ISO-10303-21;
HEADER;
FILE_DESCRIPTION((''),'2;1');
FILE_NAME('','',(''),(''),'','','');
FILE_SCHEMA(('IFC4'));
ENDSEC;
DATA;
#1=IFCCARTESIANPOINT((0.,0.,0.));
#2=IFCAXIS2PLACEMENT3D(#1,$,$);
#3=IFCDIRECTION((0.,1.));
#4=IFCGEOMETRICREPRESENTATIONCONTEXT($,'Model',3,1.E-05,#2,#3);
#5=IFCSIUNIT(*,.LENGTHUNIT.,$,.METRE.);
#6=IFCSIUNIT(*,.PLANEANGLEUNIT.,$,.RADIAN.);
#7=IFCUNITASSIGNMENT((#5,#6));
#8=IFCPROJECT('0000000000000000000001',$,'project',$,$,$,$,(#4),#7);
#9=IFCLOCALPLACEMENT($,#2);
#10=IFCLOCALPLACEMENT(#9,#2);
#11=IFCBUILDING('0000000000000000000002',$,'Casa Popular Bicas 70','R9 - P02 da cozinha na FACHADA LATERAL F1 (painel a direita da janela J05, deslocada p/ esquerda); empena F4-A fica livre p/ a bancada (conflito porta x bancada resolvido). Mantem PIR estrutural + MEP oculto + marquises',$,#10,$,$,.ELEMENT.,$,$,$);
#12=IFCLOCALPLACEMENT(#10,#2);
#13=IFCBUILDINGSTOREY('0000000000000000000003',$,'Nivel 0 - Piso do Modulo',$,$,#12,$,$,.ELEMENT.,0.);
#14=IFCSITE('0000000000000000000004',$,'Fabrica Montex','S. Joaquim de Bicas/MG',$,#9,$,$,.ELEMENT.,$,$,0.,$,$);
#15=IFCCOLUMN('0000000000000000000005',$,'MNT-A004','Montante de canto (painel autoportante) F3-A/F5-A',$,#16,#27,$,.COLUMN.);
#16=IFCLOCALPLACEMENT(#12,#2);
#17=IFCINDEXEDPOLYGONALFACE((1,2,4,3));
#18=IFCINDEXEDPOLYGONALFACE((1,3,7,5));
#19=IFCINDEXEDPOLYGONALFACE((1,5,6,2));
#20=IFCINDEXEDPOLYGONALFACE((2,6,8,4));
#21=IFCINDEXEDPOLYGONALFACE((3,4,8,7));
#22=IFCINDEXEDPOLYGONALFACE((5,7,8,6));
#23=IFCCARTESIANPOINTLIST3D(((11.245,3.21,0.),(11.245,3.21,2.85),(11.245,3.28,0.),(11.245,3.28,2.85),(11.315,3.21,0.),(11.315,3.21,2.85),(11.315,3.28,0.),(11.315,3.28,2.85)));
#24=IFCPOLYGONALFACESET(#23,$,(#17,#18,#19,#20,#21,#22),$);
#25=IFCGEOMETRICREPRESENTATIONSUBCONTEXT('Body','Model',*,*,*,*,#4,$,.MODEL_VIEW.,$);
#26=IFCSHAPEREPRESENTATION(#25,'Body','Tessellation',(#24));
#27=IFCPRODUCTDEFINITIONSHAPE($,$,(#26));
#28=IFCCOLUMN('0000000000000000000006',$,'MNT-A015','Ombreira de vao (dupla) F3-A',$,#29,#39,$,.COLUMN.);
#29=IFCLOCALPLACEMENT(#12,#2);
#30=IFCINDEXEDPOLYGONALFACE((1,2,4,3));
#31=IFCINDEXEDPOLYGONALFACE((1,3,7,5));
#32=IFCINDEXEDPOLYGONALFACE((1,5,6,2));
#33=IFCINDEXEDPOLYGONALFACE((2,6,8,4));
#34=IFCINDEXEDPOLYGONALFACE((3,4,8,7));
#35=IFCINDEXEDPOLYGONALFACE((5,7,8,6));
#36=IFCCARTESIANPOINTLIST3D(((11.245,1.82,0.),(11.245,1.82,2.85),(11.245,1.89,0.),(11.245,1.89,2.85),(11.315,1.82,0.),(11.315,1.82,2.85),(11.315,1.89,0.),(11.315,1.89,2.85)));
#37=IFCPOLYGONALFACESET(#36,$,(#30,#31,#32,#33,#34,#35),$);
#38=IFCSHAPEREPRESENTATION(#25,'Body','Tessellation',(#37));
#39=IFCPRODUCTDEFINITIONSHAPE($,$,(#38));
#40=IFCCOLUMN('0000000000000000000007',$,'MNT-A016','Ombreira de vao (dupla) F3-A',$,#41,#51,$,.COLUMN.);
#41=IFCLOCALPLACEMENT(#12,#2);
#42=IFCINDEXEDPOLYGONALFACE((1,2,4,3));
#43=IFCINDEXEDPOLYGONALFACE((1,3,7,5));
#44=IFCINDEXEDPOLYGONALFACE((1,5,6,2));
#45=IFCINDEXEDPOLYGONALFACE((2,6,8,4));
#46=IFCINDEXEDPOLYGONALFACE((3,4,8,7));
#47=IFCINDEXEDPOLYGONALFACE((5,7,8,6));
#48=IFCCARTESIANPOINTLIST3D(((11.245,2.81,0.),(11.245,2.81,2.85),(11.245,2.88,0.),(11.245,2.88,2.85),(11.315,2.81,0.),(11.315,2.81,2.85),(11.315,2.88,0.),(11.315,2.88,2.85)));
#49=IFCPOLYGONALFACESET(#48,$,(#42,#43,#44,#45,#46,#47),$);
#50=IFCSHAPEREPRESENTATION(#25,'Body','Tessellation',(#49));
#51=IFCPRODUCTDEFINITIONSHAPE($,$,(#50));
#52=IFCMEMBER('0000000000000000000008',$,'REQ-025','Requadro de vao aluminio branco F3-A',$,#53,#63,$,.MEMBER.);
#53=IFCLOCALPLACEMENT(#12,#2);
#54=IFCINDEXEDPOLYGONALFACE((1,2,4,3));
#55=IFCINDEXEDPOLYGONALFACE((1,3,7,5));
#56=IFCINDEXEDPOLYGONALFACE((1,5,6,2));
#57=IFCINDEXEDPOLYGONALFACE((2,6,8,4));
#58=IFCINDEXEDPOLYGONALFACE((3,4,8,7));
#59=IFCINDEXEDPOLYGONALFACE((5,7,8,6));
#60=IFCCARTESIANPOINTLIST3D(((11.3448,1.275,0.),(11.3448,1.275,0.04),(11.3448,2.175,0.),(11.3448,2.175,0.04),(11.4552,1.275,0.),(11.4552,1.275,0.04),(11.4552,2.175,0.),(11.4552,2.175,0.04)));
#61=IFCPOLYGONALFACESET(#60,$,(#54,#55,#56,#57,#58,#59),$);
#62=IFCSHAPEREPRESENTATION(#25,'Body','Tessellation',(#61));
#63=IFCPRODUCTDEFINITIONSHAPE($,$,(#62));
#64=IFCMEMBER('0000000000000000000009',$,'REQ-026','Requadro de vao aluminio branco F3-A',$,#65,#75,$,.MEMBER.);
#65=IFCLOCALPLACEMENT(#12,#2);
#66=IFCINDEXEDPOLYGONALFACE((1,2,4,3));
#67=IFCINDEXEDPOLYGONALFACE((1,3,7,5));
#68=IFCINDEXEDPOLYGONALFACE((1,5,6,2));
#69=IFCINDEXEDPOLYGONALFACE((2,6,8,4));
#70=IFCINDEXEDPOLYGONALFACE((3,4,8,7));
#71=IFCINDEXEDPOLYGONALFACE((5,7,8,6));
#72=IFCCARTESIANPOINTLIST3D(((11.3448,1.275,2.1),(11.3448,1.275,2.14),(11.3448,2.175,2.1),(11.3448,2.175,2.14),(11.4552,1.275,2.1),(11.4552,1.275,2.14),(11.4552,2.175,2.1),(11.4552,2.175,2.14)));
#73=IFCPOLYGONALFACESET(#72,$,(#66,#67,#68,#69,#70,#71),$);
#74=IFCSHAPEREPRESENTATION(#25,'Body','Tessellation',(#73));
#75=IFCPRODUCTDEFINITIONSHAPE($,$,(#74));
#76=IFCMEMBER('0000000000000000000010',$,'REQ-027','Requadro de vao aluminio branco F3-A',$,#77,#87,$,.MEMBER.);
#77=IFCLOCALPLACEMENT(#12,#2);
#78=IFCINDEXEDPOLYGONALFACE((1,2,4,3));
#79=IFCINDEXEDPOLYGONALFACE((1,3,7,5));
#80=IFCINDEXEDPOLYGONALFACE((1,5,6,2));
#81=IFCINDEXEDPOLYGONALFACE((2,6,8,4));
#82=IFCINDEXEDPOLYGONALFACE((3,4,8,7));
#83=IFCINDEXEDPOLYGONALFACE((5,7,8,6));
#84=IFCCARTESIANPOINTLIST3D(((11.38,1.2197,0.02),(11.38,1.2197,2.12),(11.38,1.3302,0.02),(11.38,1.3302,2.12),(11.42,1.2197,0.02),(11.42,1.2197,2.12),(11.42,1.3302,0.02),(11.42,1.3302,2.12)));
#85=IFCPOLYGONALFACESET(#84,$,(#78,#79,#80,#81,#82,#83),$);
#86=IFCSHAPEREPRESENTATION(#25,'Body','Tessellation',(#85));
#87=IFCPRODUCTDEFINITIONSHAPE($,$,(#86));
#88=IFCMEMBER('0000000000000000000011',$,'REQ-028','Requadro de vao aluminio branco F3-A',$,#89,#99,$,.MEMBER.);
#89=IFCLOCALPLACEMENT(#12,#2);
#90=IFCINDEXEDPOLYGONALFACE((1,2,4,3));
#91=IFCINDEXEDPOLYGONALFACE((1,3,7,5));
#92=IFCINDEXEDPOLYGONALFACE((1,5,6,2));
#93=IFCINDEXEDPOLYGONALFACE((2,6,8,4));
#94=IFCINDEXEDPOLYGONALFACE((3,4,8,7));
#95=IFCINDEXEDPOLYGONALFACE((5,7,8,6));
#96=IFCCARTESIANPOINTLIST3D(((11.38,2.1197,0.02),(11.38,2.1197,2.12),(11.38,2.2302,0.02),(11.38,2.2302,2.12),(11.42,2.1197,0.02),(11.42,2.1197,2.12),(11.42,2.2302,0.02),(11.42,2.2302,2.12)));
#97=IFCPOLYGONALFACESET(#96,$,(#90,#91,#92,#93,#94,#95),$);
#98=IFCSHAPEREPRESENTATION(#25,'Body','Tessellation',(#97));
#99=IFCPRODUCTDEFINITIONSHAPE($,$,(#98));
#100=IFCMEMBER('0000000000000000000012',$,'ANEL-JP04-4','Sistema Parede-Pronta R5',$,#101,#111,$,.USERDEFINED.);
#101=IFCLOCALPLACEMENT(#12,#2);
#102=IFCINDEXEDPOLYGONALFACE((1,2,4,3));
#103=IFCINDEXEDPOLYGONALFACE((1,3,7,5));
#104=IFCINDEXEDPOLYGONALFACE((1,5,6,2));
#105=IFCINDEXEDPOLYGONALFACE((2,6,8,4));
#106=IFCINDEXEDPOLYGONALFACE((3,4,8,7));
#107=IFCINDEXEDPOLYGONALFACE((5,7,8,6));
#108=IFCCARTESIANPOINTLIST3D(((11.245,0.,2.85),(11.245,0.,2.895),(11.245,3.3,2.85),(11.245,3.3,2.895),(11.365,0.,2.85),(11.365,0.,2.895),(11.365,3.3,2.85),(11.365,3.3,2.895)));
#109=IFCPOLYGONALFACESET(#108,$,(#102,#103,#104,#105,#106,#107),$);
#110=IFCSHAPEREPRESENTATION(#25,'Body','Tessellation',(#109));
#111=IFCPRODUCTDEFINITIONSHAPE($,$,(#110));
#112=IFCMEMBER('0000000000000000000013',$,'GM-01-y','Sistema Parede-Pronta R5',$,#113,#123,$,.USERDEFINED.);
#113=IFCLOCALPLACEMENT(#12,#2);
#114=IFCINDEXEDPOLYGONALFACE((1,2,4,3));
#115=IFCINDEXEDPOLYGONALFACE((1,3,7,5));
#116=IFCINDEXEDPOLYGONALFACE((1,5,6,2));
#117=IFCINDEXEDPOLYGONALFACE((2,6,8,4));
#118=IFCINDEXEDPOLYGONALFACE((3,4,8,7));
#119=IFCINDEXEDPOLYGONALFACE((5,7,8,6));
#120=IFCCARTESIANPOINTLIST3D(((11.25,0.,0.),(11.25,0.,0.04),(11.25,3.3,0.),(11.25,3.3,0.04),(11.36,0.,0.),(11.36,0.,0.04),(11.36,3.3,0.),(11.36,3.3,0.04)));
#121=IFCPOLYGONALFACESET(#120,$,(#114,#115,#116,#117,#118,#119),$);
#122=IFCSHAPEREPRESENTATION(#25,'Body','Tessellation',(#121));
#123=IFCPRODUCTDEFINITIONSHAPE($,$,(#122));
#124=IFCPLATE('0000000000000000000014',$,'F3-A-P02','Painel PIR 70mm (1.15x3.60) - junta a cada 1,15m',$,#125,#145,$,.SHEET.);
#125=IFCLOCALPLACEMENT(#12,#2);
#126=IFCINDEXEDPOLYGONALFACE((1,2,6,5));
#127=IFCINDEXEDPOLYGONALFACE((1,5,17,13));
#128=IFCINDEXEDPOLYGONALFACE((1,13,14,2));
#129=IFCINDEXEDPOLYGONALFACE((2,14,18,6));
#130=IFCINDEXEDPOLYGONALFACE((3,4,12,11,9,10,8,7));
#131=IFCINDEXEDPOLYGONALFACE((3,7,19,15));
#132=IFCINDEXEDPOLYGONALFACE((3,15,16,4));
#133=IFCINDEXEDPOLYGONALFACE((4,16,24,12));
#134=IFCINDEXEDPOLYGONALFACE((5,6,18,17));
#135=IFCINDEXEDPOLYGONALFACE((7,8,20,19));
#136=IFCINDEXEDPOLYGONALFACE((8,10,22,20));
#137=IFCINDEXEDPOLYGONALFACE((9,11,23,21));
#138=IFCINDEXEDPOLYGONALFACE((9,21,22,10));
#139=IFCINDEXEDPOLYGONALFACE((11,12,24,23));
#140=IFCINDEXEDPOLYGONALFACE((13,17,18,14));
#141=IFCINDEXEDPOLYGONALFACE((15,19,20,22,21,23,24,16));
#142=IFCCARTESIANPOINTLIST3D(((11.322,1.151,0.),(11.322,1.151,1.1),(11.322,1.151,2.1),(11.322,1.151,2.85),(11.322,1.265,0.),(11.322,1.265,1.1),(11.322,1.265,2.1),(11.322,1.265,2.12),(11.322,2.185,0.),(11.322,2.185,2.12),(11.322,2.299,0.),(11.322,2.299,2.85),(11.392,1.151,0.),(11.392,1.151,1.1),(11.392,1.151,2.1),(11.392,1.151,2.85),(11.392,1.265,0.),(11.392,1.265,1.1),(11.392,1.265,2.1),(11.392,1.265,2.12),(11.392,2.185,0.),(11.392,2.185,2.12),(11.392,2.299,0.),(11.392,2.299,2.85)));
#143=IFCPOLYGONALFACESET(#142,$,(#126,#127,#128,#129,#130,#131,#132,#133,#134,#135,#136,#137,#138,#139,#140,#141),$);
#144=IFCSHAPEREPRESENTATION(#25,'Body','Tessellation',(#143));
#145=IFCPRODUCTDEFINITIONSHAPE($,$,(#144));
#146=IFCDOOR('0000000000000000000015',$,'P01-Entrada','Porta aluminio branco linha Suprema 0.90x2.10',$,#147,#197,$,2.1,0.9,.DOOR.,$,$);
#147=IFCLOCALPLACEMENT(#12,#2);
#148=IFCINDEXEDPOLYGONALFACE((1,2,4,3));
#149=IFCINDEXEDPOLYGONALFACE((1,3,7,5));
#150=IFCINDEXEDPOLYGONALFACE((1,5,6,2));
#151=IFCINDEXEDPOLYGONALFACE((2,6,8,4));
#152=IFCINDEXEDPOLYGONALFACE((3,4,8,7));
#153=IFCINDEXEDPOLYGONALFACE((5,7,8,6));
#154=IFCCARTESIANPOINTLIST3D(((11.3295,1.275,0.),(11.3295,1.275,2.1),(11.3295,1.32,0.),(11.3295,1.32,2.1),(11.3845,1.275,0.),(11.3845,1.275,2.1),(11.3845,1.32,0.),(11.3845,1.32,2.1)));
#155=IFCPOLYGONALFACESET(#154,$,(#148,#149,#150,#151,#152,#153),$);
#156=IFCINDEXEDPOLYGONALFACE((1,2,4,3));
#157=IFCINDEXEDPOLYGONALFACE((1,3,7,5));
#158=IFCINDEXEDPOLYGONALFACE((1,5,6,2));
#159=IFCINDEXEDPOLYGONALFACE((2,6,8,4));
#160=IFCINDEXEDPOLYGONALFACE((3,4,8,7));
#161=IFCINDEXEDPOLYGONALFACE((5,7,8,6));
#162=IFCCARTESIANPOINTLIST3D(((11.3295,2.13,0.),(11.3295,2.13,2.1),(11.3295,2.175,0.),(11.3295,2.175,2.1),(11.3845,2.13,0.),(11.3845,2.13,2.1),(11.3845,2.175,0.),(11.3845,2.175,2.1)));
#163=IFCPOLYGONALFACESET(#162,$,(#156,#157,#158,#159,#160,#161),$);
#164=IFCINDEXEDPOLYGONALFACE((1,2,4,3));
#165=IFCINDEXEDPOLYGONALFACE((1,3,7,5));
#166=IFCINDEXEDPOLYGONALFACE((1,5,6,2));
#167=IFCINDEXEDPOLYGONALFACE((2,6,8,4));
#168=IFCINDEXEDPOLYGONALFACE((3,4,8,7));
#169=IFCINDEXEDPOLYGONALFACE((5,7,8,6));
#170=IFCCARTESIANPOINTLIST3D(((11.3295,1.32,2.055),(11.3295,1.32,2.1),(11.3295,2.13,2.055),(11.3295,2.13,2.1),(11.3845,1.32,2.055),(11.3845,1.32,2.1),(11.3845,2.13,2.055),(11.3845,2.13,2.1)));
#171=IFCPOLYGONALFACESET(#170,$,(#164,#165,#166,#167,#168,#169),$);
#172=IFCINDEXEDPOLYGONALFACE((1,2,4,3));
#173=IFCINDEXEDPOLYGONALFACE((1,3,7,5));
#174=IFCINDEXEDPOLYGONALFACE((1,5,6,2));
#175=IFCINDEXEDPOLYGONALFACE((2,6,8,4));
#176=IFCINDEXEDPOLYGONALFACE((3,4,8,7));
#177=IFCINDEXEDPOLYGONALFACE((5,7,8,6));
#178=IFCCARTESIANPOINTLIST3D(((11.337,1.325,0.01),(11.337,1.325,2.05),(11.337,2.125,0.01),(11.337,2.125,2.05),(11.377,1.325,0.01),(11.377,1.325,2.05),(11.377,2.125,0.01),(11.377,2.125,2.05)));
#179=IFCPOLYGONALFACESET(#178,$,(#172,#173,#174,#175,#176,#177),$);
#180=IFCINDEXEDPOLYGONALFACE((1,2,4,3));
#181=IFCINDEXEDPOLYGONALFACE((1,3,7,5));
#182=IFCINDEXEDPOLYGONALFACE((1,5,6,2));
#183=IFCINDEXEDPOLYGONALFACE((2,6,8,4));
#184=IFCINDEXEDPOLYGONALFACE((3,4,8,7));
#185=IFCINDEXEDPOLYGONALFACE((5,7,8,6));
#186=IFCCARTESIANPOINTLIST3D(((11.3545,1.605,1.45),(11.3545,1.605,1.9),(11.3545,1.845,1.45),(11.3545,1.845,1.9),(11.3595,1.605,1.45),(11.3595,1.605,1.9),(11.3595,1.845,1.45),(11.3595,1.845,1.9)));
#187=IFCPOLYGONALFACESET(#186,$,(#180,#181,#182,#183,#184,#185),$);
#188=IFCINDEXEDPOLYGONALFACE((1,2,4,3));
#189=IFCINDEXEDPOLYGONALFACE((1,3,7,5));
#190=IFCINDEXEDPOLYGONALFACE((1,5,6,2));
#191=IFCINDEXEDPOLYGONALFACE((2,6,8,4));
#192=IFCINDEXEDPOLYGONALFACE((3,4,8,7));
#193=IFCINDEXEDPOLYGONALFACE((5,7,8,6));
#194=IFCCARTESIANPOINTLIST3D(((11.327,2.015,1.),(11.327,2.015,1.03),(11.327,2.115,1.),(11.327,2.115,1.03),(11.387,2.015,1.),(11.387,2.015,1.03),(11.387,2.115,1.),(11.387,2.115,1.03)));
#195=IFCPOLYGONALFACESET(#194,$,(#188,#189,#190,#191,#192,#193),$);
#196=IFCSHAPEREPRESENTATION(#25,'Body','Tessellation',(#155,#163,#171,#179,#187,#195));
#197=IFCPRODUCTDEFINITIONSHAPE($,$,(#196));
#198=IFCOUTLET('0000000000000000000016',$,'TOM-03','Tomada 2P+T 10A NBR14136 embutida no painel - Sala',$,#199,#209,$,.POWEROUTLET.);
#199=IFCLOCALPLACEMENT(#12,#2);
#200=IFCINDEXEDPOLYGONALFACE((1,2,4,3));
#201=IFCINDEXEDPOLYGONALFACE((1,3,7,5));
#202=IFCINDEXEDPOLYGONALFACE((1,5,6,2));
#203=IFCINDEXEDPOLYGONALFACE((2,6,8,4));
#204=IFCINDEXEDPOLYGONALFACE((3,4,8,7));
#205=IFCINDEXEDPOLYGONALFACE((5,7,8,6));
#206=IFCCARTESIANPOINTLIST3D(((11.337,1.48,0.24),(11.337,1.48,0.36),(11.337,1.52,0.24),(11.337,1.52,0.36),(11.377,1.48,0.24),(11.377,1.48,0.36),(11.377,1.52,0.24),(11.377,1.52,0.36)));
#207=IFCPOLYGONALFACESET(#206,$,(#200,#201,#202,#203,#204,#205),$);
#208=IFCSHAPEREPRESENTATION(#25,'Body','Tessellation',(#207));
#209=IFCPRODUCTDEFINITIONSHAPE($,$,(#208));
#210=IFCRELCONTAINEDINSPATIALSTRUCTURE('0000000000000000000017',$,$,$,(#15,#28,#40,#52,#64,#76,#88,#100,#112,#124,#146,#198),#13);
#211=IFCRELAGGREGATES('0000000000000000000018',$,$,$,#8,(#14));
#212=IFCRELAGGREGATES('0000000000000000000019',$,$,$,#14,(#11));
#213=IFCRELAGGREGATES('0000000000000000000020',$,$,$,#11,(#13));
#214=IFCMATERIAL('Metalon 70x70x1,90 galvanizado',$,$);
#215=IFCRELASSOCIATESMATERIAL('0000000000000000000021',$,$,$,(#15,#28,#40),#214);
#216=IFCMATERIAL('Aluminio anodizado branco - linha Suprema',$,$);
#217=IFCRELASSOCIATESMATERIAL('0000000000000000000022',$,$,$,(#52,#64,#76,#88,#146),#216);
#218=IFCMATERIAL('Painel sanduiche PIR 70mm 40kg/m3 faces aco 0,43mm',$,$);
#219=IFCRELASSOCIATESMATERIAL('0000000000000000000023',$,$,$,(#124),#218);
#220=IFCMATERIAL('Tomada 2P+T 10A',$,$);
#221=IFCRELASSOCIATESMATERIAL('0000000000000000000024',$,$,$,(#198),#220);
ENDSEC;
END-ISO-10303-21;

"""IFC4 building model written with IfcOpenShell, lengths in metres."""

from ifc_helpers import new_model, si_unit, direction, frame, frame_2d, origin, origin_2d, place, context, subcontext, project, spatial, rectangle, extrude, material, element, fill, save


model = new_model("IFC4")

# Units and contexts
model_context = context("Model", 3, precision=1e-05, world=origin(), true_north=direction((0.0, 1.0)))
body_context = subcontext(model_context, "Body", "Model", "MODEL_VIEW")
ifc_project = project(units=[si_unit("LENGTHUNIT", "METRE"), si_unit("PLANEANGLEUNIT", "RADIAN")], contexts=[model_context])

# Site, building, storey
site_placement = place(None, origin())
site = spatial("IfcSite", under=ifc_project, at=site_placement, Name="Fabrica Montex", Description="S. Joaquim de Bicas/MG", CompositionType="ELEMENT", RefElevation=0.0)
building_placement = place(site_placement, origin())
building = spatial("IfcBuilding", under=site, at=building_placement, Name="Casa Popular Bicas 70", Description="R9 - P02 da cozinha na FACHADA LATERAL F1 (painel a direita da janela J05, deslocada p/ esquerda); empena F4-A fica livre p/ a bancada (conflito porta x bancada resolvido). Mantem PIR estrutural + MEP oculto + marquises", CompositionType="ELEMENT")
storey_placement = place(building_placement, origin())
storey = spatial("IfcBuildingStorey", under=building, at=storey_placement, Name="Nivel 0 - Piso do Modulo", CompositionType="ELEMENT", Elevation=0.0)

# Columns
ifc_material_1 = material(Name="Metalon 70x70x1,90 galvanizado")
for number, where, name, description in (
    (1, (11.28, 3.245, 0.0), "MNT-A004", "Montante de canto (painel autoportante) F3-A/F5-A"),
    (2, (11.28, 1.855, 0.0), "MNT-A015", "Ombreira de vao (dupla) F3-A"),
    (3, (11.28, 2.845, 0.0), "MNT-A016", "Ombreira de vao (dupla) F3-A"),
):
    element("IfcColumn", number, at=place(storey_placement, frame(where)), inside=storey, material=ifc_material_1, Name=name, Description=description, PredefinedType="COLUMN", context=body_context, shape_type="SweptSolid", body=[
        extrude(rectangle(XDim=0.07, YDim=0.07, at=origin_2d()), origin(), (0.0, 0.0, 1.0), 2.85),
    ])

# Members
ifc_material_2 = material(Name="Aluminio anodizado branco - linha Suprema")
for number, where, z_axis, x_axis, name in (
    (4, (11.4, 1.275, 0.02), (0.0, 1.0, 0.0), (0.0, 0.0, 1.0), "REQ-025"),
    (5, (11.4, 1.275, 2.12), (0.0, 1.0, 0.0), (0.0, 0.0, 1.0), "REQ-026"),
):
    element("IfcMember", number, at=place(storey_placement, frame(where, z_axis=z_axis, x_axis=x_axis)), inside=storey, material=ifc_material_2, Name=name, Description="Requadro de vao aluminio branco F3-A", PredefinedType="MEMBER", context=body_context, shape_type="SweptSolid", body=[
        extrude(rectangle(XDim=0.04, YDim=0.1105, at=origin_2d()), origin(), (0.0, 0.0, 1.0), 0.9),
    ])
for number, where, z_axis, x_axis, name in (
    (6, (11.4, 1.275, 0.02), (0.0, 0.0, 1.0), (1.0, 0.0, 0.0), "REQ-027"),
    (7, (11.4, 2.175, 0.02), (0.0, 0.0, 1.0), (1.0, 0.0, 0.0), "REQ-028"),
):
    element("IfcMember", number, at=place(storey_placement, frame(where, z_axis=z_axis, x_axis=x_axis)), inside=storey, material=ifc_material_2, Name=name, Description="Requadro de vao aluminio branco F3-A", PredefinedType="MEMBER", context=body_context, shape_type="SweptSolid", body=[
        extrude(rectangle(XDim=0.04, YDim=0.1105, at=origin_2d()), origin(), (0.0, 0.0, 1.0), 2.1),
    ])
member_1_placement = place(storey_placement, frame((11.305, 1.65, 2.85)))
element("IfcMember", 8, at=member_1_placement, inside=storey, Name="ANEL-JP04-4", Description="Sistema Parede-Pronta R5", PredefinedType="USERDEFINED", context=body_context, shape_type="SweptSolid", body=[
    extrude(rectangle(XDim=0.12, YDim=3.3, at=origin_2d()), origin(), (0.0, 0.0, 1.0), 0.045),
])
member_2_placement = place(storey_placement, frame((11.305, 1.65, 0.0)))
element("IfcMember", 9, at=member_2_placement, inside=storey, Name="GM-01-y", Description="Sistema Parede-Pronta R5", PredefinedType="USERDEFINED", context=body_context, shape_type="SweptSolid", body=[
    extrude(rectangle(XDim=0.11, YDim=3.3, at=origin_2d()), origin(), (0.0, 0.0, 1.0), 0.04),
])

# Plate, openings, door
ifc_material_3 = material(Name="Painel sanduiche PIR 70mm 40kg/m3 faces aco 0,43mm")
plate_1_placement = place(storey_placement, frame((11.357, 1.151, 0.0), x_axis=(0.0, 1.0, 0.0)))
plate_1 = element("IfcPlate", 10, at=plate_1_placement, inside=storey, material=ifc_material_3, Name="F3-A-P02", Description="Painel PIR 70mm (1.15x3.60) - junta a cada 1,15m", PredefinedType="SHEET", context=body_context, shape_type="SweptSolid", body=[
    extrude(rectangle(XDim=1.148, YDim=0.07, at=frame_2d((0.574, 0.0))), origin(), (0.0, 0.0, 1.0), 2.85),
])
opening_1_placement = place(storey_placement, frame((11.357, 1.35, 1.1)))
element("IfcOpeningElement", 11, at=opening_1_placement, cuts=plate_1, PredefinedType="OPENING", context=body_context, shape_type="SweptSolid", body=[
    extrude(rectangle(XDim=0.1, YDim=0.4, at=origin_2d()), origin(), (0.0, 0.0, 1.0), 1.0),
])
opening_2_placement = place(storey_placement, frame((11.357, 1.275, 0.0), x_axis=(0.0, 1.0, 0.0)))
opening_2 = element("IfcOpeningElement", 12, at=opening_2_placement, cuts=plate_1, PredefinedType="OPENING", context=body_context, shape_type="SweptSolid", body=[
    extrude(rectangle(XDim=0.92, YDim=0.3, at=frame_2d((0.45, 0.0))), origin(), (0.0, 0.0, 1.0), 2.12),
])
door_placement = place(storey_placement, frame((11.357, 1.275, 0.0), x_axis=(0.0, 1.0, 0.0)))
door = element("IfcDoor", 13, at=door_placement, inside=storey, material=ifc_material_2, Name="P01-Entrada", Description="Porta aluminio branco linha Suprema 0.90x2.10", OverallHeight=2.1, OverallWidth=0.9, PredefinedType="DOOR", context=body_context, shape_type="SweptSolid", body=[
    extrude(rectangle(XDim=0.045, YDim=0.055, at=frame_2d((0.0225, 0.0))), origin(), (0.0, 0.0, 1.0), 2.1),
    extrude(rectangle(XDim=0.045, YDim=0.055, at=frame_2d((0.8775, 0.0))), origin(), (0.0, 0.0, 1.0), 2.1),
    extrude(rectangle(XDim=0.81, YDim=0.055, at=frame_2d((0.45, 0.0))), frame((0.0, 0.0, 2.055)), (0.0, 0.0, 1.0), 0.045),
    extrude(rectangle(XDim=0.8, YDim=0.04, at=frame_2d((0.45, 0.0))), frame((0.0, 0.0, 0.01)), (0.0, 0.0, 1.0), 2.04),
    extrude(rectangle(XDim=0.24, YDim=0.005, at=frame_2d((0.45, 0.0))), frame((0.0, 0.0, 1.45)), (0.0, 0.0, 1.0), 0.45),
    extrude(rectangle(XDim=0.1, YDim=0.06, at=frame_2d((0.79, 0.0))), frame((0.0, 0.0, 1.0)), (0.0, 0.0, 1.0), 0.03),
])
fill(opening_2, door)

# Outlet
ifc_material_4 = material(Name="Tomada 2P+T 10A")
outlet_placement = place(storey_placement, frame((11.337, 1.48, 0.24)))
element("IfcOutlet", 14, at=outlet_placement, inside=storey, material=ifc_material_4, Name="TOM-03", Description="Tomada 2P+T 10A NBR14136 embutida no painel - Sala", PredefinedType="POWEROUTLET", context=body_context, shape_type="SweptSolid", body=[
    extrude(rectangle(XDim=0.04, YDim=0.04, at=frame_2d((0.02, 0.02))), origin(), (0.0, 0.0, 1.0), 0.12),
])

save(model, "model.ifc")
